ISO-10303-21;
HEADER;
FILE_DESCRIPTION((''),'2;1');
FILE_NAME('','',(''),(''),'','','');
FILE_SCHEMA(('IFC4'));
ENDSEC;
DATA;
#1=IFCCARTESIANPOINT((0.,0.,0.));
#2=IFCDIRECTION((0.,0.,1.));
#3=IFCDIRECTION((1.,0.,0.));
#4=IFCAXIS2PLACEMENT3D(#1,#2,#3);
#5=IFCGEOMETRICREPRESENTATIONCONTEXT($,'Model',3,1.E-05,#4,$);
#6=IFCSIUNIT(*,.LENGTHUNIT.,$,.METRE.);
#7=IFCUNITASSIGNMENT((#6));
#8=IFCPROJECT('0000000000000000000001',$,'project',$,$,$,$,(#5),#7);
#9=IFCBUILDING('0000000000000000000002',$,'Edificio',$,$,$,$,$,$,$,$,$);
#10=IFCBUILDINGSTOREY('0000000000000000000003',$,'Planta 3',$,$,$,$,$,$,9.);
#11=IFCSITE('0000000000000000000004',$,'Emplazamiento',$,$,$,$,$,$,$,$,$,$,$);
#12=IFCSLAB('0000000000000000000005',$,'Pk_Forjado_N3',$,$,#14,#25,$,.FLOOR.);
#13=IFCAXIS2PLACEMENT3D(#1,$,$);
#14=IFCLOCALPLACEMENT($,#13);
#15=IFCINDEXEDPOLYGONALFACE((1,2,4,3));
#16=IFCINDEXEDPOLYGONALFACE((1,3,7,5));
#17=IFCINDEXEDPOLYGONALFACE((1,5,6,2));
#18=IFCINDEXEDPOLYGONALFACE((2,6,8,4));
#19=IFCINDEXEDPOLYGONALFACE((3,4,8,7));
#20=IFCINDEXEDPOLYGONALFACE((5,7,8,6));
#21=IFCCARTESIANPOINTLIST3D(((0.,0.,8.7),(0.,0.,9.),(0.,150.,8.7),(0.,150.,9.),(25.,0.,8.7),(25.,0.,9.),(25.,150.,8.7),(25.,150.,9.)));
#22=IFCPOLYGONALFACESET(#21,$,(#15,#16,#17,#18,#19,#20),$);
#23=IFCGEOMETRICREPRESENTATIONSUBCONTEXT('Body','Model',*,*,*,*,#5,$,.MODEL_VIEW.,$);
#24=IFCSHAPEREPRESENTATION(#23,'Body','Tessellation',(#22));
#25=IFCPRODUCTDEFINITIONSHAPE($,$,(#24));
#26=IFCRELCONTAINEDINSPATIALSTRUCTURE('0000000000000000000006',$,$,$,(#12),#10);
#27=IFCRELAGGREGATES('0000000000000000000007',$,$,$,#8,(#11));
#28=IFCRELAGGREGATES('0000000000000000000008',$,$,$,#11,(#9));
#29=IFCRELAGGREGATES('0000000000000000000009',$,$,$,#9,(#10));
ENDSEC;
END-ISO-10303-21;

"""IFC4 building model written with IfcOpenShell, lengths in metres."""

from ifc_helpers import new_model, si_unit, frame, origin_with_axes, place, context, subcontext, project, spatial, polyline, outline, extrude, element, save


model = new_model("IFC4")

# Units and contexts
model_context = context("Model", 3, precision=1e-05, world=origin_with_axes())
body_context = subcontext(model_context, "Body", "Model", "MODEL_VIEW")
ifc_project = project(units=[si_unit("LENGTHUNIT", "METRE")], contexts=[model_context])

# Site, building, storey
site = spatial("IfcSite", under=ifc_project, Name="Emplazamiento")
building = spatial("IfcBuilding", under=site, Name="Edificio")
storey = spatial("IfcBuildingStorey", under=building, Name="Planta 3", Elevation=9.0)

# Slab
slab_placement = place(None, frame((0.0, 0.0, 9.0), z_axis=(0.0, 0.0, 1.0), x_axis=(1.0, 0.0, 0.0)))
element("IfcSlab", 1, at=slab_placement, inside=storey, Name="Pk_Forjado_N3", PredefinedType="FLOOR", context=body_context, shape_type="SweptSolid", body=[
    extrude(outline(polyline([(0.0, 0.0), (25.0, 0.0), (25.0, 150.0), (0.0, 150.0), (0.0, 0.0)])), frame((0.0, 0.0, -0.3), z_axis=(0.0, 0.0, 1.0), x_axis=(1.0, 0.0, 0.0)), (0.0, 0.0, 1.0), 0.3),
])

save(model, "model.ifc")
